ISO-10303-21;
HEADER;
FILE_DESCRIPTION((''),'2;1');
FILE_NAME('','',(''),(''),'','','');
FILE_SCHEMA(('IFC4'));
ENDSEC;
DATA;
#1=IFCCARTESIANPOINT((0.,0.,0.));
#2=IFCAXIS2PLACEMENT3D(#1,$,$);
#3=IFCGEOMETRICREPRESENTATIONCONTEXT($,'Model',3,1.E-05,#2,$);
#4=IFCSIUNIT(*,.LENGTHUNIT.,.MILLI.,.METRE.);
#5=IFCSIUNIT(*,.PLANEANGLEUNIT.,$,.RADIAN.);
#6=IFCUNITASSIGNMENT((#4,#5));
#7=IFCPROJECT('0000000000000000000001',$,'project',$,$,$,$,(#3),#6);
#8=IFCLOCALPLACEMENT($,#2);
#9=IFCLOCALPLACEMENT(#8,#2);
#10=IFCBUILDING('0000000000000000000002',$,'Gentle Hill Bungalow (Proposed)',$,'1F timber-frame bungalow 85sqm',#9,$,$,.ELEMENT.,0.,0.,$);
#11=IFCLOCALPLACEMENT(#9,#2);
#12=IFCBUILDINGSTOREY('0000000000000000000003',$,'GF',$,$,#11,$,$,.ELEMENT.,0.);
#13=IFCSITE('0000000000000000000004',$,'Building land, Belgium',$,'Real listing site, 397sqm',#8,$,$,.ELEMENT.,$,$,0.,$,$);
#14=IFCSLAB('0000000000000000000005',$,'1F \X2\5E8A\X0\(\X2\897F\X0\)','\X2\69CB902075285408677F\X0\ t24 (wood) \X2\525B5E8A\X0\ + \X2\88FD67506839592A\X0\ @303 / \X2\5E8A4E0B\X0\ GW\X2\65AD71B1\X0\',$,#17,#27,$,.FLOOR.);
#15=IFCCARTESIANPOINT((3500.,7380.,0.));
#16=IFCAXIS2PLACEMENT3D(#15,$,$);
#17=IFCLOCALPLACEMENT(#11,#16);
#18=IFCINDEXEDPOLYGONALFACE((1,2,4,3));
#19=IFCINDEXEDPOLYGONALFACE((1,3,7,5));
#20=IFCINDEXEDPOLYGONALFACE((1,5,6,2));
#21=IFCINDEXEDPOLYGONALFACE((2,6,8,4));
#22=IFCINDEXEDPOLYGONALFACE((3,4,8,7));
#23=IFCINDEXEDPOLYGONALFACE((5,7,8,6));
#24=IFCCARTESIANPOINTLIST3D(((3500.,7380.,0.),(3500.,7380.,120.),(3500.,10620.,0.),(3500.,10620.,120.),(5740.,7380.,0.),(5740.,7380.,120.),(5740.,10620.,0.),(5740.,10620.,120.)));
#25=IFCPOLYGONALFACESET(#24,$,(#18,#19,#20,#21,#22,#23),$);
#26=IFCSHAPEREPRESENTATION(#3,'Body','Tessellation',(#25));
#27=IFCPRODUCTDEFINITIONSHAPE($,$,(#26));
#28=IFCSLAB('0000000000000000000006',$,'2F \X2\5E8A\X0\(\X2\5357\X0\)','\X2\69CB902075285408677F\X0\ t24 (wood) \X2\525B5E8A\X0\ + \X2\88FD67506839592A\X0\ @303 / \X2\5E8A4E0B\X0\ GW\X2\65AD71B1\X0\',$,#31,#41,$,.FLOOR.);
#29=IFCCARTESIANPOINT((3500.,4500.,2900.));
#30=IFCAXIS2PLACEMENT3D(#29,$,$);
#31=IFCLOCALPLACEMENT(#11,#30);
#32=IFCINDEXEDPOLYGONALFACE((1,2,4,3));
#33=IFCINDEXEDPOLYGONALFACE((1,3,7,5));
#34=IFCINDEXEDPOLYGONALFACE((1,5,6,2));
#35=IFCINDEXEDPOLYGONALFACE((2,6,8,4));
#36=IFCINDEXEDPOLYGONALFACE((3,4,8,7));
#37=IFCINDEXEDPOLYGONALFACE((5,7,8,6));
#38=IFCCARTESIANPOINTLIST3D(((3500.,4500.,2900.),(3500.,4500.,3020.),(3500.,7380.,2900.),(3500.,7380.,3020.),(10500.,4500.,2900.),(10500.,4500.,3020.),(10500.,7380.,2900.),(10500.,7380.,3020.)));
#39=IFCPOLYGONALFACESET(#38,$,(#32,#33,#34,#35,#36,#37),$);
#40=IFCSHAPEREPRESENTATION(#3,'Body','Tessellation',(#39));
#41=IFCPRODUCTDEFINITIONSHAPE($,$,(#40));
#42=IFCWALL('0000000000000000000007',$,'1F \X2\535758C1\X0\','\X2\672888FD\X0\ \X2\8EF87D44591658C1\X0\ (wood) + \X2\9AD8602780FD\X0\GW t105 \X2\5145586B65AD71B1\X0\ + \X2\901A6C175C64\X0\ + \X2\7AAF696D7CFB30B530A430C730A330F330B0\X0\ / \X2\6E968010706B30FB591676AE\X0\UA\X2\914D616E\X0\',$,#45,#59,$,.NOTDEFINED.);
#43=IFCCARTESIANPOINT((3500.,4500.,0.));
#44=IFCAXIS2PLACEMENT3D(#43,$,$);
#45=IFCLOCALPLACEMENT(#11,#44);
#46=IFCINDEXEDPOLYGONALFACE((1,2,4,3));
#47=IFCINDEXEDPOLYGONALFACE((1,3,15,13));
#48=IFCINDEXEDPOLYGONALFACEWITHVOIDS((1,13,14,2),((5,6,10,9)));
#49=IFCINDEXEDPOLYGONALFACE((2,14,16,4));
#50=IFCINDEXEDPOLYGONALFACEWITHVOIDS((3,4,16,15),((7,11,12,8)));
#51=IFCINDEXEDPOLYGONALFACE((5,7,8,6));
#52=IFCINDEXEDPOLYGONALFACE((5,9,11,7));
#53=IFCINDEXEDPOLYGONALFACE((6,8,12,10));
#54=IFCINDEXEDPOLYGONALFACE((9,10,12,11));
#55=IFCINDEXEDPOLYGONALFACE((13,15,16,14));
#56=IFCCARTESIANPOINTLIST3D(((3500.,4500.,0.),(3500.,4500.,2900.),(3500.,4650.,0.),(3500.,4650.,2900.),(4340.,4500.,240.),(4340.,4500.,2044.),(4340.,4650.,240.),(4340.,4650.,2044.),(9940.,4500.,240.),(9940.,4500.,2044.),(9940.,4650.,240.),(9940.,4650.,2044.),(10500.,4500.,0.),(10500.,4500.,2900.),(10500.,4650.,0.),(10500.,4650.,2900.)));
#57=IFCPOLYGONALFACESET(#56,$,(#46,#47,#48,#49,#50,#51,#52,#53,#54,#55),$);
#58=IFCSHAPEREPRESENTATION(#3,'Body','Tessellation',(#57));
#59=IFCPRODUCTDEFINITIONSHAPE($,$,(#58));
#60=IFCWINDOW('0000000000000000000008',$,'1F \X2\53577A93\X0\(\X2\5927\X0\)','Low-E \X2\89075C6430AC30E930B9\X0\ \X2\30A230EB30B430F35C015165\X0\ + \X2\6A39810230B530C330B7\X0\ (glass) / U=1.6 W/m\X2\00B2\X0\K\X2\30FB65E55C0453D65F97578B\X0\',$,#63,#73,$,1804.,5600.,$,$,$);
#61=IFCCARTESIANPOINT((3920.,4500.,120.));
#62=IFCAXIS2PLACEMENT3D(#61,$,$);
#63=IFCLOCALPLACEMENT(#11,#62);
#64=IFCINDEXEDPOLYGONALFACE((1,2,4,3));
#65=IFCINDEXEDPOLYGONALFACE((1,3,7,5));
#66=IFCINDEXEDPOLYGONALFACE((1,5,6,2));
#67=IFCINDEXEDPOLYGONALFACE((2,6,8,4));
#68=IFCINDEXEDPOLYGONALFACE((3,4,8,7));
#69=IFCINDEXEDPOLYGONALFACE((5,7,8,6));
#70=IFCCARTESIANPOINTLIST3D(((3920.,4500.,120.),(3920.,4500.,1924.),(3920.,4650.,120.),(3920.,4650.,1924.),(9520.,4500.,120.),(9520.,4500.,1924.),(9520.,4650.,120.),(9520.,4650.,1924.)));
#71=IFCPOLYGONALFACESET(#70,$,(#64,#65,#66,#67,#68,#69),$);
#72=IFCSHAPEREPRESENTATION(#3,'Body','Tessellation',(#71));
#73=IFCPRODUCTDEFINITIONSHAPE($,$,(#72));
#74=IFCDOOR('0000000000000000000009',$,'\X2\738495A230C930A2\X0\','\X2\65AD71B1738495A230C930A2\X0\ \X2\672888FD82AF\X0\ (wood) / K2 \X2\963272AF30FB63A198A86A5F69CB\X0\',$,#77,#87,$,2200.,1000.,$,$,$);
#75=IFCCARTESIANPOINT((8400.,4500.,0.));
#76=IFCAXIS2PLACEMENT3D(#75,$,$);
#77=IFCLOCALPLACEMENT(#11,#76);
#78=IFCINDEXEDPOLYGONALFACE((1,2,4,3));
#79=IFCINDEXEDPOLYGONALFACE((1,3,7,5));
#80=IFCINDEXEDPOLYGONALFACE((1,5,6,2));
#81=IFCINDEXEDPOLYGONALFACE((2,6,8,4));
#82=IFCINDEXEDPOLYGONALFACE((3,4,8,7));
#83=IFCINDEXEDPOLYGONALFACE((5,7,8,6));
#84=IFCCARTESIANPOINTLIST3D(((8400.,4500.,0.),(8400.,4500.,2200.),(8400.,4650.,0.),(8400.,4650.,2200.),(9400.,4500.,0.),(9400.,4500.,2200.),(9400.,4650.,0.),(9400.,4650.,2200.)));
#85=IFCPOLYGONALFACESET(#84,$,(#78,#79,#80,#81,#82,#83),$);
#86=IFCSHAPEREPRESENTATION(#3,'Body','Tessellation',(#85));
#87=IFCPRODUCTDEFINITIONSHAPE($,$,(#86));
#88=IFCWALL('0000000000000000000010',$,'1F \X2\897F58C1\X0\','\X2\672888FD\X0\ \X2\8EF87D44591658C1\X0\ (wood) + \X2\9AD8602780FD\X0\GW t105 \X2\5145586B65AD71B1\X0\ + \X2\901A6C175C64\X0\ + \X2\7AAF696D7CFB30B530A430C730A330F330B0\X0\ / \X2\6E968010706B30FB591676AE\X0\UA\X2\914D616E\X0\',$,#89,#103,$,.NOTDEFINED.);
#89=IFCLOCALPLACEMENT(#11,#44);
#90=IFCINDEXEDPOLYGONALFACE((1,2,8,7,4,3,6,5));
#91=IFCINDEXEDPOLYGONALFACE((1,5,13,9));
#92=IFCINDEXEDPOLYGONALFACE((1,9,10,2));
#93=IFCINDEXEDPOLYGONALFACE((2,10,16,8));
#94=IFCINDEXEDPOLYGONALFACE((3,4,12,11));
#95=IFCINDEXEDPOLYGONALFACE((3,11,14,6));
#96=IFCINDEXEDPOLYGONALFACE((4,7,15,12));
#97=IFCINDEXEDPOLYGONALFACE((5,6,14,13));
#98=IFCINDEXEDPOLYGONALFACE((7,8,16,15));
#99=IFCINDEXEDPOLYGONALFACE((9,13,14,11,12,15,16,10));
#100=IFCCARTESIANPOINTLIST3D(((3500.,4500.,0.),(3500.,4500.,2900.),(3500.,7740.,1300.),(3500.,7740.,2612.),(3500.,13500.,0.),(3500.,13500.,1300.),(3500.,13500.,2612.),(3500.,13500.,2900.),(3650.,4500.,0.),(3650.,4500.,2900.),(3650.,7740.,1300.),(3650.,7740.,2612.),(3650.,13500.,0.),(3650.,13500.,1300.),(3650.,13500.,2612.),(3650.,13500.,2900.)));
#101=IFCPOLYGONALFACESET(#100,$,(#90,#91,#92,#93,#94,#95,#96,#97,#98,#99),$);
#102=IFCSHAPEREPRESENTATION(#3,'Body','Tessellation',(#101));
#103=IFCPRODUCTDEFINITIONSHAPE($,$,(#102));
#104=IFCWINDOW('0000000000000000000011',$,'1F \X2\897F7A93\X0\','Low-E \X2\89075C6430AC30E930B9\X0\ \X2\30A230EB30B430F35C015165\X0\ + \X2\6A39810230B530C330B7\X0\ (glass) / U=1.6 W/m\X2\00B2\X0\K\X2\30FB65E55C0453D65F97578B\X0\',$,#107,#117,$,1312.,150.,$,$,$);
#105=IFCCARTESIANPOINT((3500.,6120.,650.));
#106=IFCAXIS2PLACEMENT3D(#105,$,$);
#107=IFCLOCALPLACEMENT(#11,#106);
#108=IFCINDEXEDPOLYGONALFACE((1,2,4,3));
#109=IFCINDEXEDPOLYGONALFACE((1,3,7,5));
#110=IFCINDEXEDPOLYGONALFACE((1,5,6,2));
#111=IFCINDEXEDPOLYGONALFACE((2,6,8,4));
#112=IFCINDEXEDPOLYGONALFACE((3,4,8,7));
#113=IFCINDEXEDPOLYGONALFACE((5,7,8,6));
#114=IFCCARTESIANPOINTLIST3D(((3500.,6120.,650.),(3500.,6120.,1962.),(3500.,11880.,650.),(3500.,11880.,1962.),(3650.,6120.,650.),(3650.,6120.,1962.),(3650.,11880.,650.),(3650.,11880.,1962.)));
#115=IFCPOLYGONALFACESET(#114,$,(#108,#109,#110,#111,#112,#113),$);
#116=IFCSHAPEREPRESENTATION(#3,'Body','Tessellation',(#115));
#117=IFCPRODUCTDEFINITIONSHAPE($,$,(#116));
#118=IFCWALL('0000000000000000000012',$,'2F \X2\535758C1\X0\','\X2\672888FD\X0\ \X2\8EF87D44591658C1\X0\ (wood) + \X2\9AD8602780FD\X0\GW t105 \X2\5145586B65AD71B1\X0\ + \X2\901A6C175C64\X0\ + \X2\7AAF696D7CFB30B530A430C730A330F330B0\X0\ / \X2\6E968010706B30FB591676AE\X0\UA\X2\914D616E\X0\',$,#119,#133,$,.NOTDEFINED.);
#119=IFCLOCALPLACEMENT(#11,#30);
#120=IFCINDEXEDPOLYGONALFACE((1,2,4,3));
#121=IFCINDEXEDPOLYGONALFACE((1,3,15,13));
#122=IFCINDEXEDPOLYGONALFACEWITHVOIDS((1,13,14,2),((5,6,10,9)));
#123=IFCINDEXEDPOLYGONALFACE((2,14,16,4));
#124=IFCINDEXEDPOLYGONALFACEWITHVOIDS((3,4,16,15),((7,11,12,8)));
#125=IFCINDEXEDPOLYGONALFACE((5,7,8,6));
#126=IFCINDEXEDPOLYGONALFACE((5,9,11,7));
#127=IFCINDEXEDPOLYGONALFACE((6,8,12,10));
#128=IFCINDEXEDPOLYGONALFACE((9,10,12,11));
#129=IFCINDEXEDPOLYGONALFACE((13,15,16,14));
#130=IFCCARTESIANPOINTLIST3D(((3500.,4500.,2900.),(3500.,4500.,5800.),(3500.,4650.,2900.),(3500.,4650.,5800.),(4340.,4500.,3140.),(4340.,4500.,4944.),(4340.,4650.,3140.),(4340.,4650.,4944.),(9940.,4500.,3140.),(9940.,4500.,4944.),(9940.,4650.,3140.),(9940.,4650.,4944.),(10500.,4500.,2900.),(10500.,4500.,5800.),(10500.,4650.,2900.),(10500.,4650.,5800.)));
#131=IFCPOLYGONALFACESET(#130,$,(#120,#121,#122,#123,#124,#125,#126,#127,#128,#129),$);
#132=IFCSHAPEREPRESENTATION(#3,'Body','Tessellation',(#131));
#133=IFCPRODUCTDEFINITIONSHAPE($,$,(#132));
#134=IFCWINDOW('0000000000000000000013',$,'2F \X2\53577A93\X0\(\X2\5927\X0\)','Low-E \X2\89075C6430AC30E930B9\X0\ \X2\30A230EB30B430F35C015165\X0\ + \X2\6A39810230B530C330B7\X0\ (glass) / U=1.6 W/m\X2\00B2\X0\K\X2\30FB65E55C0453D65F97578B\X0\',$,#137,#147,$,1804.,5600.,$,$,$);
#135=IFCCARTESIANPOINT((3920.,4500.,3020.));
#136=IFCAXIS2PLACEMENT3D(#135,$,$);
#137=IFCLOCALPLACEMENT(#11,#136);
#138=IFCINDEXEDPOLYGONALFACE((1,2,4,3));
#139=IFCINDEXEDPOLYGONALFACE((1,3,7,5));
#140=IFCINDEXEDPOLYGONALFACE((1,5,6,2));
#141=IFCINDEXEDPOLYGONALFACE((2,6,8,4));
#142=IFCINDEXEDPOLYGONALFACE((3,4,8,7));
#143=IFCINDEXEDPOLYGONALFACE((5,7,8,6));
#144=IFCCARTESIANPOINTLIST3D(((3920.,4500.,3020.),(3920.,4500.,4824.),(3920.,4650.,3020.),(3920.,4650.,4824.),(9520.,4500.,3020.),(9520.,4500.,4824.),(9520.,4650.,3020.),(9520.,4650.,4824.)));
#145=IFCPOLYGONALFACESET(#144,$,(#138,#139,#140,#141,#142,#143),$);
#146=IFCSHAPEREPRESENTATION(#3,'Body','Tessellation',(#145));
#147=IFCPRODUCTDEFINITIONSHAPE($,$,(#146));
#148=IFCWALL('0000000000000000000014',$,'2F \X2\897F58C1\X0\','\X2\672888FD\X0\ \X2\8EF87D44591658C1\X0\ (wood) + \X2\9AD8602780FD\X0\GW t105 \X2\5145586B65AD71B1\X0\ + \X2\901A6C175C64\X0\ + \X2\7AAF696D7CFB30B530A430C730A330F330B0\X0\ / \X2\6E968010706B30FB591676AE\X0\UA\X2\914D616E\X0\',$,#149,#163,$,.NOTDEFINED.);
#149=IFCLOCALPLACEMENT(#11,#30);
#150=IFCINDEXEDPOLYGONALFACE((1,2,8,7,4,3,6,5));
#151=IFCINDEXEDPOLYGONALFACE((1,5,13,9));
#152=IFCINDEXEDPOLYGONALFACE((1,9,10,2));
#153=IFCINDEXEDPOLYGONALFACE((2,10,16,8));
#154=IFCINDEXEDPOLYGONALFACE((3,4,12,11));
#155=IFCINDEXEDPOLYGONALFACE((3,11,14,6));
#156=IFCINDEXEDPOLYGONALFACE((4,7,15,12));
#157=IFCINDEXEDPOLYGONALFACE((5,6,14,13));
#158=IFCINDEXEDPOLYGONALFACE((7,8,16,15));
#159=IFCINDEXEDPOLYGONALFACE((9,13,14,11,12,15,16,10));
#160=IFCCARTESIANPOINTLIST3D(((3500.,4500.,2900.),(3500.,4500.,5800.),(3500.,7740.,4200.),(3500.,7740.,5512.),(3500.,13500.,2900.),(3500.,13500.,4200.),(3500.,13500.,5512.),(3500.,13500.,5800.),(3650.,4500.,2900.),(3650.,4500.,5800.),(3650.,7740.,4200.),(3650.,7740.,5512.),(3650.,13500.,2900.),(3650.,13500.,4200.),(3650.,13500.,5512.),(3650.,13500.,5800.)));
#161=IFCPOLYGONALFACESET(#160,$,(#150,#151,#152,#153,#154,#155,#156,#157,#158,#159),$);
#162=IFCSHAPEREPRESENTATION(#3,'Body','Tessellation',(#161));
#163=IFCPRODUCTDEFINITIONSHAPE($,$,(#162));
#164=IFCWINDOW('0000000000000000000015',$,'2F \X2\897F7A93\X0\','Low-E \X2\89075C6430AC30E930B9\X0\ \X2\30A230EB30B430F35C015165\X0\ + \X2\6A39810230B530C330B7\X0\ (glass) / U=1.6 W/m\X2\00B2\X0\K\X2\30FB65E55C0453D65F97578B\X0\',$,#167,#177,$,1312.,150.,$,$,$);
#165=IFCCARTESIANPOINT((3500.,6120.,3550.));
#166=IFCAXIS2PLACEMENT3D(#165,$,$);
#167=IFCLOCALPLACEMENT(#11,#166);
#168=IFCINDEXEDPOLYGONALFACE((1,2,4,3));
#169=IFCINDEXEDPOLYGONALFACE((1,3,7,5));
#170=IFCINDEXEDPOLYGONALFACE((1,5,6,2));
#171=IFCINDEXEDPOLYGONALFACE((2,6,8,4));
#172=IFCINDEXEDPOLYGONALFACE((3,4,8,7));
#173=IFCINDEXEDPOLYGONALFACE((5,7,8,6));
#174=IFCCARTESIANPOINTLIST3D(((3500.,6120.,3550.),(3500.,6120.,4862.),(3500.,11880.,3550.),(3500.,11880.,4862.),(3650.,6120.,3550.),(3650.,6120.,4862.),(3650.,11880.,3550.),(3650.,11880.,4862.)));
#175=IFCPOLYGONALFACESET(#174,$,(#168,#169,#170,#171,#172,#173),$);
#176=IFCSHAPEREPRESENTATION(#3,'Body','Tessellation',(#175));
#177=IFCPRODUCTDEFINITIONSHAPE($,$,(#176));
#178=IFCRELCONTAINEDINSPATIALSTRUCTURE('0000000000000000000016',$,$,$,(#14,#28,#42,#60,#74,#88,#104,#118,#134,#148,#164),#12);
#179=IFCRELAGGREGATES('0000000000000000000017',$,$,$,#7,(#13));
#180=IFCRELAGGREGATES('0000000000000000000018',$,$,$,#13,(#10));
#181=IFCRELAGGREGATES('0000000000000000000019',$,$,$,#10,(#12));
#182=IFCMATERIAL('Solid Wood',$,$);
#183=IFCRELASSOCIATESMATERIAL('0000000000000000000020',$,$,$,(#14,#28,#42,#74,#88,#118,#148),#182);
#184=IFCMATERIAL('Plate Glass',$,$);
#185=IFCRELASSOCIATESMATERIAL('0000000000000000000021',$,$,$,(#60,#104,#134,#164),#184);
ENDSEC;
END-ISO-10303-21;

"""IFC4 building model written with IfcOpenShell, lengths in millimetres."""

from ifc_helpers import new_model, si_unit, frame, frame_2d, origin, place, context, project, spatial, rectangle, extrude, material, element, fill, save


model = new_model("IFC4")

# Units and contexts
model_context = context("Model", 3, precision=1e-05, world=origin())
ifc_project = project(units=[si_unit("LENGTHUNIT", "METRE", prefix="MILLI"), si_unit("PLANEANGLEUNIT", "RADIAN")], contexts=[model_context])

# Site, building, storey
site_placement = place(None, origin())
site = spatial("IfcSite", under=ifc_project, at=site_placement, Name="Building land, Belgium", ObjectType="Real listing site, 397sqm", CompositionType="ELEMENT", RefElevation=0.0)
building_placement = place(site_placement, origin())
building = spatial("IfcBuilding", under=site, at=building_placement, Name="Gentle Hill Bungalow (Proposed)", ObjectType="1F timber-frame bungalow 85sqm", CompositionType="ELEMENT", ElevationOfRefHeight=0.0, ElevationOfTerrain=0.0)
storey_placement = place(building_placement, origin())
storey = spatial("IfcBuildingStorey", under=building, at=storey_placement, Name="GF", CompositionType="ELEMENT", Elevation=0.0)

# Slabs
ifc_material_1 = material(Name="Solid Wood")
slab_1_placement = place(storey_placement, frame((3500.0, 7380.0, 0.0)))
element("IfcSlab", 1, at=slab_1_placement, inside=storey, material=ifc_material_1, Name="1F 床(西)", Description="構造用合板 t24 (wood) 剛床 + 製材根太 @303 / 床下 GW断熱", PredefinedType="FLOOR", context=model_context, shape_type="SweptSolid", body=[
    extrude(rectangle(XDim=2240.0, YDim=3240.0, at=frame_2d((1120.0, 1620.0))), frame((3500.0, 7380.0, 0.0)), (0.0, 0.0, 1.0), 120.0),
])
slab_2_placement = place(storey_placement, frame((3500.0, 4500.0, 2900.0)))
element("IfcSlab", 2, at=slab_2_placement, inside=storey, material=ifc_material_1, Name="2F 床(南)", Description="構造用合板 t24 (wood) 剛床 + 製材根太 @303 / 床下 GW断熱", PredefinedType="FLOOR", context=model_context, shape_type="SweptSolid", body=[
    extrude(rectangle(XDim=7000.0, YDim=2880.0, at=frame_2d((3500.0, 1440.0))), frame((3500.0, 4500.0, 2900.0)), (0.0, 0.0, 1.0), 120.0),
])

# Wall, openings, window, door
wall_1_placement = place(storey_placement, frame((3500.0, 4500.0, 0.0)))
wall_1 = element("IfcWall", 3, at=wall_1_placement, inside=storey, material=ifc_material_1, Name="1F 南壁", Description="木製 軸組外壁 (wood) + 高性能GW t105 充填断熱 + 通気層 + 窯業系サイディング / 準耐火・外皮UA配慮", PredefinedType="NOTDEFINED", context=model_context, shape_type="SweptSolid", body=[
    extrude(rectangle(XDim=7000.0, YDim=150.0, at=frame_2d((3500.0, 75.0))), frame((3500.0, 4500.0, 0.0)), (0.0, 0.0, 1.0), 2900.0),
])
opening_1_placement = place(storey_placement, frame((3920.0, 4500.0, 120.0)))
opening_1 = element("IfcOpeningElement", 4, at=opening_1_placement, cuts=wall_1, PredefinedType="NOTDEFINED", context=model_context, shape_type="SweptSolid", body=[
    extrude(rectangle(XDim=5600.0, YDim=150.0, at=frame_2d((2800.0, 75.0))), frame((3920.0, 4500.0, 120.0)), (0.0, 0.0, 1.0), 1804.0),
])
opening_2_placement = place(storey_placement, frame((8400.0, 4500.0, 0.0)))
opening_2 = element("IfcOpeningElement", 5, at=opening_2_placement, cuts=wall_1, PredefinedType="NOTDEFINED", context=model_context, shape_type="SweptSolid", body=[
    extrude(rectangle(XDim=1000.0, YDim=150.0, at=frame_2d((500.0, 75.0))), frame((8400.0, 4500.0, 0.0)), (0.0, 0.0, 1.0), 2200.0),
])
ifc_material_2 = material(Name="Plate Glass")
window_1_placement = place(storey_placement, frame((3920.0, 4500.0, 120.0)))
window_1 = element("IfcWindow", 6, at=window_1_placement, inside=storey, material=ifc_material_2, Name="1F 南窓(大)", Description="Low-E 複層ガラス アルゴン封入 + 樹脂サッシ (glass) / U=1.6 W/m²K・日射取得型", OverallHeight=1804.0, OverallWidth=5600.0, context=model_context, shape_type="SweptSolid", body=[
    extrude(rectangle(XDim=5600.0, YDim=150.0, at=frame_2d((2800.0, 75.0))), frame((3920.0, 4500.0, 120.0)), (0.0, 0.0, 1.0), 1804.0),
])
fill(opening_1, window_1)
door_placement = place(storey_placement, frame((8400.0, 4500.0, 0.0)))
door = element("IfcDoor", 7, at=door_placement, inside=storey, material=ifc_material_1, Name="玄関ドア", Description="断熱玄関ドア 木製芯 (wood) / K2 防犯・採風機構", OverallHeight=2200.0, OverallWidth=1000.0, context=model_context, shape_type="SweptSolid", body=[
    extrude(rectangle(XDim=1000.0, YDim=150.0, at=frame_2d((500.0, 75.0))), frame((8400.0, 4500.0, 0.0)), (0.0, 0.0, 1.0), 2200.0),
])
fill(opening_2, door)

# Walls, openings, windows
wall_2_placement = place(storey_placement, frame((3500.0, 4500.0, 0.0)))
wall_2 = element("IfcWall", 8, at=wall_2_placement, inside=storey, material=ifc_material_1, Name="1F 西壁", Description="木製 軸組外壁 (wood) + 高性能GW t105 充填断熱 + 通気層 + 窯業系サイディング / 準耐火・外皮UA配慮", PredefinedType="NOTDEFINED", context=model_context, shape_type="SweptSolid", body=[
    extrude(rectangle(XDim=150.0, YDim=9000.0, at=frame_2d((75.0, 4500.0))), frame((3500.0, 4500.0, 0.0)), (0.0, 0.0, 1.0), 2900.0),
])
opening_3_placement = place(storey_placement, frame((3500.0, 6120.0, 650.0)))
opening_3 = element("IfcOpeningElement", 9, at=opening_3_placement, cuts=wall_2, PredefinedType="NOTDEFINED", context=model_context, shape_type="SweptSolid", body=[
    extrude(rectangle(XDim=150.0, YDim=5760.0, at=frame_2d((75.0, 2880.0))), frame((3500.0, 6120.0, 650.0)), (0.0, 0.0, 1.0), 1312.0),
])
window_2_placement = place(storey_placement, frame((3500.0, 6120.0, 650.0)))
window_2 = element("IfcWindow", 10, at=window_2_placement, inside=storey, material=ifc_material_2, Name="1F 西窓", Description="Low-E 複層ガラス アルゴン封入 + 樹脂サッシ (glass) / U=1.6 W/m²K・日射取得型", OverallHeight=1312.0, OverallWidth=150.0, context=model_context, shape_type="SweptSolid", body=[
    extrude(rectangle(XDim=150.0, YDim=5760.0, at=frame_2d((75.0, 2880.0))), frame((3500.0, 6120.0, 650.0)), (0.0, 0.0, 1.0), 1312.0),
])
fill(opening_3, window_2)
wall_3_placement = place(storey_placement, frame((3500.0, 4500.0, 2900.0)))
wall_3 = element("IfcWall", 11, at=wall_3_placement, inside=storey, material=ifc_material_1, Name="2F 南壁", Description="木製 軸組外壁 (wood) + 高性能GW t105 充填断熱 + 通気層 + 窯業系サイディング / 準耐火・外皮UA配慮", PredefinedType="NOTDEFINED", context=model_context, shape_type="SweptSolid", body=[
    extrude(rectangle(XDim=7000.0, YDim=150.0, at=frame_2d((3500.0, 75.0))), frame((3500.0, 4500.0, 2900.0)), (0.0, 0.0, 1.0), 2900.0),
])
opening_4_placement = place(storey_placement, frame((3920.0, 4500.0, 3020.0)))
opening_4 = element("IfcOpeningElement", 12, at=opening_4_placement, cuts=wall_3, PredefinedType="NOTDEFINED", context=model_context, shape_type="SweptSolid", body=[
    extrude(rectangle(XDim=5600.0, YDim=150.0, at=frame_2d((2800.0, 75.0))), frame((3920.0, 4500.0, 3020.0)), (0.0, 0.0, 1.0), 1804.0),
])
window_3_placement = place(storey_placement, frame((3920.0, 4500.0, 3020.0)))
window_3 = element("IfcWindow", 13, at=window_3_placement, inside=storey, material=ifc_material_2, Name="2F 南窓(大)", Description="Low-E 複層ガラス アルゴン封入 + 樹脂サッシ (glass) / U=1.6 W/m²K・日射取得型", OverallHeight=1804.0, OverallWidth=5600.0, context=model_context, shape_type="SweptSolid", body=[
    extrude(rectangle(XDim=5600.0, YDim=150.0, at=frame_2d((2800.0, 75.0))), frame((3920.0, 4500.0, 3020.0)), (0.0, 0.0, 1.0), 1804.0),
])
fill(opening_4, window_3)
wall_4_placement = place(storey_placement, frame((3500.0, 4500.0, 2900.0)))
wall_4 = element("IfcWall", 14, at=wall_4_placement, inside=storey, material=ifc_material_1, Name="2F 西壁", Description="木製 軸組外壁 (wood) + 高性能GW t105 充填断熱 + 通気層 + 窯業系サイディング / 準耐火・外皮UA配慮", PredefinedType="NOTDEFINED", context=model_context, shape_type="SweptSolid", body=[
    extrude(rectangle(XDim=150.0, YDim=9000.0, at=frame_2d((75.0, 4500.0))), frame((3500.0, 4500.0, 2900.0)), (0.0, 0.0, 1.0), 2900.0),
])
opening_5_placement = place(storey_placement, frame((3500.0, 6120.0, 3550.0)))
opening_5 = element("IfcOpeningElement", 15, at=opening_5_placement, cuts=wall_4, PredefinedType="NOTDEFINED", context=model_context, shape_type="SweptSolid", body=[
    extrude(rectangle(XDim=150.0, YDim=5760.0, at=frame_2d((75.0, 2880.0))), frame((3500.0, 6120.0, 3550.0)), (0.0, 0.0, 1.0), 1312.0),
])
window_4_placement = place(storey_placement, frame((3500.0, 6120.0, 3550.0)))
window_4 = element("IfcWindow", 16, at=window_4_placement, inside=storey, material=ifc_material_2, Name="2F 西窓", Description="Low-E 複層ガラス アルゴン封入 + 樹脂サッシ (glass) / U=1.6 W/m²K・日射取得型", OverallHeight=1312.0, OverallWidth=150.0, context=model_context, shape_type="SweptSolid", body=[
    extrude(rectangle(XDim=150.0, YDim=5760.0, at=frame_2d((75.0, 2880.0))), frame((3500.0, 6120.0, 3550.0)), (0.0, 0.0, 1.0), 1312.0),
])
fill(opening_5, window_4)

save(model, "model.ifc")
